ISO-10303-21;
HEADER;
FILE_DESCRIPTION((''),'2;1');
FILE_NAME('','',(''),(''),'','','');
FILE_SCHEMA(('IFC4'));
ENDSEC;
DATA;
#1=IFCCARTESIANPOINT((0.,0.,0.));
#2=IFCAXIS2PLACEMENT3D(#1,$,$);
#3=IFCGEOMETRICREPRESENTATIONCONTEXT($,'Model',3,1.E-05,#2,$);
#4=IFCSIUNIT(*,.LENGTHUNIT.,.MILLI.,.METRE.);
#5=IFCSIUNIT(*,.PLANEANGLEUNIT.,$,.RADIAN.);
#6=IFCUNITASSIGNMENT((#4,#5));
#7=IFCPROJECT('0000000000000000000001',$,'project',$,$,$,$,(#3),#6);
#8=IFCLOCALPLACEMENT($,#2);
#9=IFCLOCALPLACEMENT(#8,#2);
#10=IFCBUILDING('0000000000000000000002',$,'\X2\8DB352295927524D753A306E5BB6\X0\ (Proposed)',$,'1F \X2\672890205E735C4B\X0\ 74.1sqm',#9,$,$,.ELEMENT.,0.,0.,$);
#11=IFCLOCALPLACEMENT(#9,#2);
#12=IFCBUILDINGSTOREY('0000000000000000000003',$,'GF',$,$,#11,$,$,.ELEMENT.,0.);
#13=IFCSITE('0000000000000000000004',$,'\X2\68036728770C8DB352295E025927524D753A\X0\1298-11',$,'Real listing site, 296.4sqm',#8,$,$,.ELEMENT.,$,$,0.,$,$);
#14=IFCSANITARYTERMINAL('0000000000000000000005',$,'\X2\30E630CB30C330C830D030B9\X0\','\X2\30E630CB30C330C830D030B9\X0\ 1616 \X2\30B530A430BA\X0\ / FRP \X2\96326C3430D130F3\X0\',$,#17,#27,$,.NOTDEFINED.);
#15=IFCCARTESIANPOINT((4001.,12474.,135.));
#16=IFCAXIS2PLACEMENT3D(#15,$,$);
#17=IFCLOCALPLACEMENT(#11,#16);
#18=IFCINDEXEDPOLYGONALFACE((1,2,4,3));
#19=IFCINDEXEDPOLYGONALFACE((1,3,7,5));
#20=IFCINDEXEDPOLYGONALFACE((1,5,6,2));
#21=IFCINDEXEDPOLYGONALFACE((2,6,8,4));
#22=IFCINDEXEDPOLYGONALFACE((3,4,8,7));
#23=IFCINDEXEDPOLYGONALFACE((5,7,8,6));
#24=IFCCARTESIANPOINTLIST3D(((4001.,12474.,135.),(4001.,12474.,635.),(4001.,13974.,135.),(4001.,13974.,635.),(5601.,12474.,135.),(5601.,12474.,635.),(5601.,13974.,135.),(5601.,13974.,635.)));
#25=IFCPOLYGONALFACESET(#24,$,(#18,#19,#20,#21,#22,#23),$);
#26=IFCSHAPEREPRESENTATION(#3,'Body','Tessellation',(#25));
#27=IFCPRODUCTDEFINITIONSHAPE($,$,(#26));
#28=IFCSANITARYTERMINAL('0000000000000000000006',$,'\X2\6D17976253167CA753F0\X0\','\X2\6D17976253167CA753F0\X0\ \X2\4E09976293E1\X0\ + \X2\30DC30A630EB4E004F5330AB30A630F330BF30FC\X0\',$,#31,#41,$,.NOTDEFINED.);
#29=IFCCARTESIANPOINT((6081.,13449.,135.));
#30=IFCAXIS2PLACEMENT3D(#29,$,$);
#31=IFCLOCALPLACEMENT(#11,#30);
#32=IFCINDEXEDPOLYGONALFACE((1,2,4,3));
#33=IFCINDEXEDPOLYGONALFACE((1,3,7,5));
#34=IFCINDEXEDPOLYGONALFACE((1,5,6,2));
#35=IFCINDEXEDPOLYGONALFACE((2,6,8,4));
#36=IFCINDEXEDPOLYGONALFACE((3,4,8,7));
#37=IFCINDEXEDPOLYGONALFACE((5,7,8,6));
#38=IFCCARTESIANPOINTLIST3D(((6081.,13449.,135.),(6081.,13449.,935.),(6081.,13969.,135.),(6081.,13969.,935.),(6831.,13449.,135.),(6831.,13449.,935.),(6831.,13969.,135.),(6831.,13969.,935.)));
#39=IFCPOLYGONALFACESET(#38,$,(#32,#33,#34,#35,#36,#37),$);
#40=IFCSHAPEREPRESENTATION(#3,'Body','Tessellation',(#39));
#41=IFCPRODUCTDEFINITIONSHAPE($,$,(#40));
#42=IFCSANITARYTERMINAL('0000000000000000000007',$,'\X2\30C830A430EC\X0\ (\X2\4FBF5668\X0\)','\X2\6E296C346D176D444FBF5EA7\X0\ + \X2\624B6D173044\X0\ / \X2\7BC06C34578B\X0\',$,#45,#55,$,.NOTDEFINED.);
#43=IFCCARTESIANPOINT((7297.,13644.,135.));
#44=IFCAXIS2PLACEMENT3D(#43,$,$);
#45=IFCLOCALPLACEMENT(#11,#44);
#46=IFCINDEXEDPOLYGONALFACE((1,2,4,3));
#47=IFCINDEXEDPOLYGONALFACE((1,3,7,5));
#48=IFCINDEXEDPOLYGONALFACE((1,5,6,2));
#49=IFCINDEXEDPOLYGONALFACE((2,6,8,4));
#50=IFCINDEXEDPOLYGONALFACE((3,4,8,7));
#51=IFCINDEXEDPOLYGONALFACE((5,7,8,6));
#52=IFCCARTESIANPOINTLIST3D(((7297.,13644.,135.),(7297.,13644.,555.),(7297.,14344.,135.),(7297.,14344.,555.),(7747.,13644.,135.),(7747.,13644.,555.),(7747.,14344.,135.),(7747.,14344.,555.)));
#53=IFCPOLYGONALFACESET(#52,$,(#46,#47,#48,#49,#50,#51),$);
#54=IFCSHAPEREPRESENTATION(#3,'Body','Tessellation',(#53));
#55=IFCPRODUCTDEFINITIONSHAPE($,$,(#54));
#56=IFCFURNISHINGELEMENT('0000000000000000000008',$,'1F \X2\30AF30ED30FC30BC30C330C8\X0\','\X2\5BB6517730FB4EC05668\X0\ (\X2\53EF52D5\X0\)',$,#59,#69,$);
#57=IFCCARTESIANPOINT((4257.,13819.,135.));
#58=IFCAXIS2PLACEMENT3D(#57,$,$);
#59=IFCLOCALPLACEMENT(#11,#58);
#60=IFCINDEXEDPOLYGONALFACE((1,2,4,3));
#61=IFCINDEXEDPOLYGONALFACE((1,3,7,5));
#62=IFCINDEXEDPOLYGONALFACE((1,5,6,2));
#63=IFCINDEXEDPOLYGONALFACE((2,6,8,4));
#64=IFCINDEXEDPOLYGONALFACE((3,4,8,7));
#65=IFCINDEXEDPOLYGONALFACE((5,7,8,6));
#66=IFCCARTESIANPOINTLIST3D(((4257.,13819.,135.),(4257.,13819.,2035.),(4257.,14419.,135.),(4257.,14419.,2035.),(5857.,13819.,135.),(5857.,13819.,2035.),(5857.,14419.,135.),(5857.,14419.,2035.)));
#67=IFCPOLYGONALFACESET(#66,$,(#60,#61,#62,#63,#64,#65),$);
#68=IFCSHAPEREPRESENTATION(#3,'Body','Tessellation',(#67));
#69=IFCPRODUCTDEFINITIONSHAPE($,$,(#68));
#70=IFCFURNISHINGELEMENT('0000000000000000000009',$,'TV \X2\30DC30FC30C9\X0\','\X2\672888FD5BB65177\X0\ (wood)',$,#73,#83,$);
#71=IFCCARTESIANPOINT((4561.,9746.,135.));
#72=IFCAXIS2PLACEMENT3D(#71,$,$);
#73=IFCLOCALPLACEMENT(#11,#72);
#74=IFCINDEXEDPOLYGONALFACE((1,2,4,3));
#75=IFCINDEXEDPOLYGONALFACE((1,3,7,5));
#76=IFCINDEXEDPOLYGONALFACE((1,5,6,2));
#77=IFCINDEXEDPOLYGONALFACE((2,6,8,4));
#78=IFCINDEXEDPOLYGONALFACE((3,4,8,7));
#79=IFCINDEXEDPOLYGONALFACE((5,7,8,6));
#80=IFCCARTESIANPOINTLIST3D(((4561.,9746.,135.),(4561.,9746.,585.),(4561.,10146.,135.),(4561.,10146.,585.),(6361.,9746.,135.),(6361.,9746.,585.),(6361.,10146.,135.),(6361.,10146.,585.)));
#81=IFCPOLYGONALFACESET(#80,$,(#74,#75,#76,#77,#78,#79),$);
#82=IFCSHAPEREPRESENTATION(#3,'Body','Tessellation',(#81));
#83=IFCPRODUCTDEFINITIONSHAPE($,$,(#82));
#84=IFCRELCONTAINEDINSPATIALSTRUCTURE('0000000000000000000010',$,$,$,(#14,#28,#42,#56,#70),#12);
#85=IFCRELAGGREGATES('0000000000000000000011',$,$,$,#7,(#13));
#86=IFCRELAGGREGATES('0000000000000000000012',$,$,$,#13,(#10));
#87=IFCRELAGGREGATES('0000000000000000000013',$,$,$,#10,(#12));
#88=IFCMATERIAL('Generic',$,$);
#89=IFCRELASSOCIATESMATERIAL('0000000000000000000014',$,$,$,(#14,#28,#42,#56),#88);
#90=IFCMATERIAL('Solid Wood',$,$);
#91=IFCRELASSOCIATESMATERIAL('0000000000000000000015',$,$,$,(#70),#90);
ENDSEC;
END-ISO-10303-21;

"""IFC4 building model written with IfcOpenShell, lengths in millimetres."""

from ifc_helpers import new_model, si_unit, frame, frame_2d, origin, place, context, project, spatial, rectangle, extrude, material, element, save


model = new_model("IFC4")

# Units and contexts
model_context = context("Model", 3, precision=1e-05, world=origin())
ifc_project = project(units=[si_unit("LENGTHUNIT", "METRE", prefix="MILLI"), si_unit("PLANEANGLEUNIT", "RADIAN")], contexts=[model_context])

# Site, building, storey
site_placement = place(None, origin())
site = spatial("IfcSite", under=ifc_project, at=site_placement, Name="栃木県足利市大前町1298-11", ObjectType="Real listing site, 296.4sqm", CompositionType="ELEMENT", RefElevation=0.0)
building_placement = place(site_placement, origin())
building = spatial("IfcBuilding", under=site, at=building_placement, Name="足利大前町の家 (Proposed)", ObjectType="1F 木造平屋 74.1sqm", CompositionType="ELEMENT", ElevationOfRefHeight=0.0, ElevationOfTerrain=0.0)
storey_placement = place(building_placement, origin())
storey = spatial("IfcBuildingStorey", under=building, at=storey_placement, Name="GF", CompositionType="ELEMENT", Elevation=0.0)

# Shared definitions
ifc_material_1 = material(Name="Solid Wood")

# Shared definitions
ifc_material_2 = material(Name="Generic")

# Sanitary terminals
sanitary_terminal_1_placement = place(storey_placement, frame((4001.0, 12474.0, 135.0)))
element("IfcSanitaryTerminal", 1, at=sanitary_terminal_1_placement, inside=storey, material=ifc_material_2, Name="ユニットバス", Description="ユニットバス 1616 サイズ / FRP 防水パン", PredefinedType="NOTDEFINED", context=model_context, shape_type="SweptSolid", body=[
    extrude(rectangle(XDim=1600.0, YDim=1500.0, at=frame_2d((800.0, 750.0))), frame((4001.0, 12474.0, 135.0)), (0.0, 0.0, 1.0), 500.0),
])
sanitary_terminal_2_placement = place(storey_placement, frame((6081.0, 13449.0, 135.0)))
element("IfcSanitaryTerminal", 2, at=sanitary_terminal_2_placement, inside=storey, material=ifc_material_2, Name="洗面化粧台", Description="洗面化粧台 三面鏡 + ボウル一体カウンター", PredefinedType="NOTDEFINED", context=model_context, shape_type="SweptSolid", body=[
    extrude(rectangle(XDim=750.0, YDim=520.0, at=frame_2d((375.0, 260.0))), frame((6081.0, 13449.0, 135.0)), (0.0, 0.0, 1.0), 800.0),
])
sanitary_terminal_3_placement = place(storey_placement, frame((7297.0, 13644.0, 135.0)))
element("IfcSanitaryTerminal", 3, at=sanitary_terminal_3_placement, inside=storey, material=ifc_material_2, Name="トイレ (便器)", Description="温水洗浄便座 + 手洗い / 節水型", PredefinedType="NOTDEFINED", context=model_context, shape_type="SweptSolid", body=[
    extrude(rectangle(XDim=450.0, YDim=700.0, at=frame_2d((225.0, 350.0))), frame((7297.0, 13644.0, 135.0)), (0.0, 0.0, 1.0), 420.0),
])

# Furnishing elements
furnishing_1_placement = place(storey_placement, frame((4257.0, 13819.0, 135.0)))
element("IfcFurnishingElement", 4, at=furnishing_1_placement, inside=storey, material=ifc_material_2, Name="1F クローゼット", Description="家具・什器 (可動)", context=model_context, shape_type="SweptSolid", body=[
    extrude(rectangle(XDim=1600.0, YDim=600.0, at=frame_2d((800.0, 300.0))), frame((4257.0, 13819.0, 135.0)), (0.0, 0.0, 1.0), 1900.0),
])
furnishing_2_placement = place(storey_placement, frame((4561.0, 9746.0, 135.0)))
element("IfcFurnishingElement", 5, at=furnishing_2_placement, inside=storey, material=ifc_material_1, Name="TV ボード", Description="木製家具 (wood)", context=model_context, shape_type="SweptSolid", body=[
    extrude(rectangle(XDim=1800.0, YDim=400.0, at=frame_2d((900.0, 200.0))), frame((4561.0, 9746.0, 135.0)), (0.0, 0.0, 1.0), 450.0),
])

save(model, "model.ifc")
